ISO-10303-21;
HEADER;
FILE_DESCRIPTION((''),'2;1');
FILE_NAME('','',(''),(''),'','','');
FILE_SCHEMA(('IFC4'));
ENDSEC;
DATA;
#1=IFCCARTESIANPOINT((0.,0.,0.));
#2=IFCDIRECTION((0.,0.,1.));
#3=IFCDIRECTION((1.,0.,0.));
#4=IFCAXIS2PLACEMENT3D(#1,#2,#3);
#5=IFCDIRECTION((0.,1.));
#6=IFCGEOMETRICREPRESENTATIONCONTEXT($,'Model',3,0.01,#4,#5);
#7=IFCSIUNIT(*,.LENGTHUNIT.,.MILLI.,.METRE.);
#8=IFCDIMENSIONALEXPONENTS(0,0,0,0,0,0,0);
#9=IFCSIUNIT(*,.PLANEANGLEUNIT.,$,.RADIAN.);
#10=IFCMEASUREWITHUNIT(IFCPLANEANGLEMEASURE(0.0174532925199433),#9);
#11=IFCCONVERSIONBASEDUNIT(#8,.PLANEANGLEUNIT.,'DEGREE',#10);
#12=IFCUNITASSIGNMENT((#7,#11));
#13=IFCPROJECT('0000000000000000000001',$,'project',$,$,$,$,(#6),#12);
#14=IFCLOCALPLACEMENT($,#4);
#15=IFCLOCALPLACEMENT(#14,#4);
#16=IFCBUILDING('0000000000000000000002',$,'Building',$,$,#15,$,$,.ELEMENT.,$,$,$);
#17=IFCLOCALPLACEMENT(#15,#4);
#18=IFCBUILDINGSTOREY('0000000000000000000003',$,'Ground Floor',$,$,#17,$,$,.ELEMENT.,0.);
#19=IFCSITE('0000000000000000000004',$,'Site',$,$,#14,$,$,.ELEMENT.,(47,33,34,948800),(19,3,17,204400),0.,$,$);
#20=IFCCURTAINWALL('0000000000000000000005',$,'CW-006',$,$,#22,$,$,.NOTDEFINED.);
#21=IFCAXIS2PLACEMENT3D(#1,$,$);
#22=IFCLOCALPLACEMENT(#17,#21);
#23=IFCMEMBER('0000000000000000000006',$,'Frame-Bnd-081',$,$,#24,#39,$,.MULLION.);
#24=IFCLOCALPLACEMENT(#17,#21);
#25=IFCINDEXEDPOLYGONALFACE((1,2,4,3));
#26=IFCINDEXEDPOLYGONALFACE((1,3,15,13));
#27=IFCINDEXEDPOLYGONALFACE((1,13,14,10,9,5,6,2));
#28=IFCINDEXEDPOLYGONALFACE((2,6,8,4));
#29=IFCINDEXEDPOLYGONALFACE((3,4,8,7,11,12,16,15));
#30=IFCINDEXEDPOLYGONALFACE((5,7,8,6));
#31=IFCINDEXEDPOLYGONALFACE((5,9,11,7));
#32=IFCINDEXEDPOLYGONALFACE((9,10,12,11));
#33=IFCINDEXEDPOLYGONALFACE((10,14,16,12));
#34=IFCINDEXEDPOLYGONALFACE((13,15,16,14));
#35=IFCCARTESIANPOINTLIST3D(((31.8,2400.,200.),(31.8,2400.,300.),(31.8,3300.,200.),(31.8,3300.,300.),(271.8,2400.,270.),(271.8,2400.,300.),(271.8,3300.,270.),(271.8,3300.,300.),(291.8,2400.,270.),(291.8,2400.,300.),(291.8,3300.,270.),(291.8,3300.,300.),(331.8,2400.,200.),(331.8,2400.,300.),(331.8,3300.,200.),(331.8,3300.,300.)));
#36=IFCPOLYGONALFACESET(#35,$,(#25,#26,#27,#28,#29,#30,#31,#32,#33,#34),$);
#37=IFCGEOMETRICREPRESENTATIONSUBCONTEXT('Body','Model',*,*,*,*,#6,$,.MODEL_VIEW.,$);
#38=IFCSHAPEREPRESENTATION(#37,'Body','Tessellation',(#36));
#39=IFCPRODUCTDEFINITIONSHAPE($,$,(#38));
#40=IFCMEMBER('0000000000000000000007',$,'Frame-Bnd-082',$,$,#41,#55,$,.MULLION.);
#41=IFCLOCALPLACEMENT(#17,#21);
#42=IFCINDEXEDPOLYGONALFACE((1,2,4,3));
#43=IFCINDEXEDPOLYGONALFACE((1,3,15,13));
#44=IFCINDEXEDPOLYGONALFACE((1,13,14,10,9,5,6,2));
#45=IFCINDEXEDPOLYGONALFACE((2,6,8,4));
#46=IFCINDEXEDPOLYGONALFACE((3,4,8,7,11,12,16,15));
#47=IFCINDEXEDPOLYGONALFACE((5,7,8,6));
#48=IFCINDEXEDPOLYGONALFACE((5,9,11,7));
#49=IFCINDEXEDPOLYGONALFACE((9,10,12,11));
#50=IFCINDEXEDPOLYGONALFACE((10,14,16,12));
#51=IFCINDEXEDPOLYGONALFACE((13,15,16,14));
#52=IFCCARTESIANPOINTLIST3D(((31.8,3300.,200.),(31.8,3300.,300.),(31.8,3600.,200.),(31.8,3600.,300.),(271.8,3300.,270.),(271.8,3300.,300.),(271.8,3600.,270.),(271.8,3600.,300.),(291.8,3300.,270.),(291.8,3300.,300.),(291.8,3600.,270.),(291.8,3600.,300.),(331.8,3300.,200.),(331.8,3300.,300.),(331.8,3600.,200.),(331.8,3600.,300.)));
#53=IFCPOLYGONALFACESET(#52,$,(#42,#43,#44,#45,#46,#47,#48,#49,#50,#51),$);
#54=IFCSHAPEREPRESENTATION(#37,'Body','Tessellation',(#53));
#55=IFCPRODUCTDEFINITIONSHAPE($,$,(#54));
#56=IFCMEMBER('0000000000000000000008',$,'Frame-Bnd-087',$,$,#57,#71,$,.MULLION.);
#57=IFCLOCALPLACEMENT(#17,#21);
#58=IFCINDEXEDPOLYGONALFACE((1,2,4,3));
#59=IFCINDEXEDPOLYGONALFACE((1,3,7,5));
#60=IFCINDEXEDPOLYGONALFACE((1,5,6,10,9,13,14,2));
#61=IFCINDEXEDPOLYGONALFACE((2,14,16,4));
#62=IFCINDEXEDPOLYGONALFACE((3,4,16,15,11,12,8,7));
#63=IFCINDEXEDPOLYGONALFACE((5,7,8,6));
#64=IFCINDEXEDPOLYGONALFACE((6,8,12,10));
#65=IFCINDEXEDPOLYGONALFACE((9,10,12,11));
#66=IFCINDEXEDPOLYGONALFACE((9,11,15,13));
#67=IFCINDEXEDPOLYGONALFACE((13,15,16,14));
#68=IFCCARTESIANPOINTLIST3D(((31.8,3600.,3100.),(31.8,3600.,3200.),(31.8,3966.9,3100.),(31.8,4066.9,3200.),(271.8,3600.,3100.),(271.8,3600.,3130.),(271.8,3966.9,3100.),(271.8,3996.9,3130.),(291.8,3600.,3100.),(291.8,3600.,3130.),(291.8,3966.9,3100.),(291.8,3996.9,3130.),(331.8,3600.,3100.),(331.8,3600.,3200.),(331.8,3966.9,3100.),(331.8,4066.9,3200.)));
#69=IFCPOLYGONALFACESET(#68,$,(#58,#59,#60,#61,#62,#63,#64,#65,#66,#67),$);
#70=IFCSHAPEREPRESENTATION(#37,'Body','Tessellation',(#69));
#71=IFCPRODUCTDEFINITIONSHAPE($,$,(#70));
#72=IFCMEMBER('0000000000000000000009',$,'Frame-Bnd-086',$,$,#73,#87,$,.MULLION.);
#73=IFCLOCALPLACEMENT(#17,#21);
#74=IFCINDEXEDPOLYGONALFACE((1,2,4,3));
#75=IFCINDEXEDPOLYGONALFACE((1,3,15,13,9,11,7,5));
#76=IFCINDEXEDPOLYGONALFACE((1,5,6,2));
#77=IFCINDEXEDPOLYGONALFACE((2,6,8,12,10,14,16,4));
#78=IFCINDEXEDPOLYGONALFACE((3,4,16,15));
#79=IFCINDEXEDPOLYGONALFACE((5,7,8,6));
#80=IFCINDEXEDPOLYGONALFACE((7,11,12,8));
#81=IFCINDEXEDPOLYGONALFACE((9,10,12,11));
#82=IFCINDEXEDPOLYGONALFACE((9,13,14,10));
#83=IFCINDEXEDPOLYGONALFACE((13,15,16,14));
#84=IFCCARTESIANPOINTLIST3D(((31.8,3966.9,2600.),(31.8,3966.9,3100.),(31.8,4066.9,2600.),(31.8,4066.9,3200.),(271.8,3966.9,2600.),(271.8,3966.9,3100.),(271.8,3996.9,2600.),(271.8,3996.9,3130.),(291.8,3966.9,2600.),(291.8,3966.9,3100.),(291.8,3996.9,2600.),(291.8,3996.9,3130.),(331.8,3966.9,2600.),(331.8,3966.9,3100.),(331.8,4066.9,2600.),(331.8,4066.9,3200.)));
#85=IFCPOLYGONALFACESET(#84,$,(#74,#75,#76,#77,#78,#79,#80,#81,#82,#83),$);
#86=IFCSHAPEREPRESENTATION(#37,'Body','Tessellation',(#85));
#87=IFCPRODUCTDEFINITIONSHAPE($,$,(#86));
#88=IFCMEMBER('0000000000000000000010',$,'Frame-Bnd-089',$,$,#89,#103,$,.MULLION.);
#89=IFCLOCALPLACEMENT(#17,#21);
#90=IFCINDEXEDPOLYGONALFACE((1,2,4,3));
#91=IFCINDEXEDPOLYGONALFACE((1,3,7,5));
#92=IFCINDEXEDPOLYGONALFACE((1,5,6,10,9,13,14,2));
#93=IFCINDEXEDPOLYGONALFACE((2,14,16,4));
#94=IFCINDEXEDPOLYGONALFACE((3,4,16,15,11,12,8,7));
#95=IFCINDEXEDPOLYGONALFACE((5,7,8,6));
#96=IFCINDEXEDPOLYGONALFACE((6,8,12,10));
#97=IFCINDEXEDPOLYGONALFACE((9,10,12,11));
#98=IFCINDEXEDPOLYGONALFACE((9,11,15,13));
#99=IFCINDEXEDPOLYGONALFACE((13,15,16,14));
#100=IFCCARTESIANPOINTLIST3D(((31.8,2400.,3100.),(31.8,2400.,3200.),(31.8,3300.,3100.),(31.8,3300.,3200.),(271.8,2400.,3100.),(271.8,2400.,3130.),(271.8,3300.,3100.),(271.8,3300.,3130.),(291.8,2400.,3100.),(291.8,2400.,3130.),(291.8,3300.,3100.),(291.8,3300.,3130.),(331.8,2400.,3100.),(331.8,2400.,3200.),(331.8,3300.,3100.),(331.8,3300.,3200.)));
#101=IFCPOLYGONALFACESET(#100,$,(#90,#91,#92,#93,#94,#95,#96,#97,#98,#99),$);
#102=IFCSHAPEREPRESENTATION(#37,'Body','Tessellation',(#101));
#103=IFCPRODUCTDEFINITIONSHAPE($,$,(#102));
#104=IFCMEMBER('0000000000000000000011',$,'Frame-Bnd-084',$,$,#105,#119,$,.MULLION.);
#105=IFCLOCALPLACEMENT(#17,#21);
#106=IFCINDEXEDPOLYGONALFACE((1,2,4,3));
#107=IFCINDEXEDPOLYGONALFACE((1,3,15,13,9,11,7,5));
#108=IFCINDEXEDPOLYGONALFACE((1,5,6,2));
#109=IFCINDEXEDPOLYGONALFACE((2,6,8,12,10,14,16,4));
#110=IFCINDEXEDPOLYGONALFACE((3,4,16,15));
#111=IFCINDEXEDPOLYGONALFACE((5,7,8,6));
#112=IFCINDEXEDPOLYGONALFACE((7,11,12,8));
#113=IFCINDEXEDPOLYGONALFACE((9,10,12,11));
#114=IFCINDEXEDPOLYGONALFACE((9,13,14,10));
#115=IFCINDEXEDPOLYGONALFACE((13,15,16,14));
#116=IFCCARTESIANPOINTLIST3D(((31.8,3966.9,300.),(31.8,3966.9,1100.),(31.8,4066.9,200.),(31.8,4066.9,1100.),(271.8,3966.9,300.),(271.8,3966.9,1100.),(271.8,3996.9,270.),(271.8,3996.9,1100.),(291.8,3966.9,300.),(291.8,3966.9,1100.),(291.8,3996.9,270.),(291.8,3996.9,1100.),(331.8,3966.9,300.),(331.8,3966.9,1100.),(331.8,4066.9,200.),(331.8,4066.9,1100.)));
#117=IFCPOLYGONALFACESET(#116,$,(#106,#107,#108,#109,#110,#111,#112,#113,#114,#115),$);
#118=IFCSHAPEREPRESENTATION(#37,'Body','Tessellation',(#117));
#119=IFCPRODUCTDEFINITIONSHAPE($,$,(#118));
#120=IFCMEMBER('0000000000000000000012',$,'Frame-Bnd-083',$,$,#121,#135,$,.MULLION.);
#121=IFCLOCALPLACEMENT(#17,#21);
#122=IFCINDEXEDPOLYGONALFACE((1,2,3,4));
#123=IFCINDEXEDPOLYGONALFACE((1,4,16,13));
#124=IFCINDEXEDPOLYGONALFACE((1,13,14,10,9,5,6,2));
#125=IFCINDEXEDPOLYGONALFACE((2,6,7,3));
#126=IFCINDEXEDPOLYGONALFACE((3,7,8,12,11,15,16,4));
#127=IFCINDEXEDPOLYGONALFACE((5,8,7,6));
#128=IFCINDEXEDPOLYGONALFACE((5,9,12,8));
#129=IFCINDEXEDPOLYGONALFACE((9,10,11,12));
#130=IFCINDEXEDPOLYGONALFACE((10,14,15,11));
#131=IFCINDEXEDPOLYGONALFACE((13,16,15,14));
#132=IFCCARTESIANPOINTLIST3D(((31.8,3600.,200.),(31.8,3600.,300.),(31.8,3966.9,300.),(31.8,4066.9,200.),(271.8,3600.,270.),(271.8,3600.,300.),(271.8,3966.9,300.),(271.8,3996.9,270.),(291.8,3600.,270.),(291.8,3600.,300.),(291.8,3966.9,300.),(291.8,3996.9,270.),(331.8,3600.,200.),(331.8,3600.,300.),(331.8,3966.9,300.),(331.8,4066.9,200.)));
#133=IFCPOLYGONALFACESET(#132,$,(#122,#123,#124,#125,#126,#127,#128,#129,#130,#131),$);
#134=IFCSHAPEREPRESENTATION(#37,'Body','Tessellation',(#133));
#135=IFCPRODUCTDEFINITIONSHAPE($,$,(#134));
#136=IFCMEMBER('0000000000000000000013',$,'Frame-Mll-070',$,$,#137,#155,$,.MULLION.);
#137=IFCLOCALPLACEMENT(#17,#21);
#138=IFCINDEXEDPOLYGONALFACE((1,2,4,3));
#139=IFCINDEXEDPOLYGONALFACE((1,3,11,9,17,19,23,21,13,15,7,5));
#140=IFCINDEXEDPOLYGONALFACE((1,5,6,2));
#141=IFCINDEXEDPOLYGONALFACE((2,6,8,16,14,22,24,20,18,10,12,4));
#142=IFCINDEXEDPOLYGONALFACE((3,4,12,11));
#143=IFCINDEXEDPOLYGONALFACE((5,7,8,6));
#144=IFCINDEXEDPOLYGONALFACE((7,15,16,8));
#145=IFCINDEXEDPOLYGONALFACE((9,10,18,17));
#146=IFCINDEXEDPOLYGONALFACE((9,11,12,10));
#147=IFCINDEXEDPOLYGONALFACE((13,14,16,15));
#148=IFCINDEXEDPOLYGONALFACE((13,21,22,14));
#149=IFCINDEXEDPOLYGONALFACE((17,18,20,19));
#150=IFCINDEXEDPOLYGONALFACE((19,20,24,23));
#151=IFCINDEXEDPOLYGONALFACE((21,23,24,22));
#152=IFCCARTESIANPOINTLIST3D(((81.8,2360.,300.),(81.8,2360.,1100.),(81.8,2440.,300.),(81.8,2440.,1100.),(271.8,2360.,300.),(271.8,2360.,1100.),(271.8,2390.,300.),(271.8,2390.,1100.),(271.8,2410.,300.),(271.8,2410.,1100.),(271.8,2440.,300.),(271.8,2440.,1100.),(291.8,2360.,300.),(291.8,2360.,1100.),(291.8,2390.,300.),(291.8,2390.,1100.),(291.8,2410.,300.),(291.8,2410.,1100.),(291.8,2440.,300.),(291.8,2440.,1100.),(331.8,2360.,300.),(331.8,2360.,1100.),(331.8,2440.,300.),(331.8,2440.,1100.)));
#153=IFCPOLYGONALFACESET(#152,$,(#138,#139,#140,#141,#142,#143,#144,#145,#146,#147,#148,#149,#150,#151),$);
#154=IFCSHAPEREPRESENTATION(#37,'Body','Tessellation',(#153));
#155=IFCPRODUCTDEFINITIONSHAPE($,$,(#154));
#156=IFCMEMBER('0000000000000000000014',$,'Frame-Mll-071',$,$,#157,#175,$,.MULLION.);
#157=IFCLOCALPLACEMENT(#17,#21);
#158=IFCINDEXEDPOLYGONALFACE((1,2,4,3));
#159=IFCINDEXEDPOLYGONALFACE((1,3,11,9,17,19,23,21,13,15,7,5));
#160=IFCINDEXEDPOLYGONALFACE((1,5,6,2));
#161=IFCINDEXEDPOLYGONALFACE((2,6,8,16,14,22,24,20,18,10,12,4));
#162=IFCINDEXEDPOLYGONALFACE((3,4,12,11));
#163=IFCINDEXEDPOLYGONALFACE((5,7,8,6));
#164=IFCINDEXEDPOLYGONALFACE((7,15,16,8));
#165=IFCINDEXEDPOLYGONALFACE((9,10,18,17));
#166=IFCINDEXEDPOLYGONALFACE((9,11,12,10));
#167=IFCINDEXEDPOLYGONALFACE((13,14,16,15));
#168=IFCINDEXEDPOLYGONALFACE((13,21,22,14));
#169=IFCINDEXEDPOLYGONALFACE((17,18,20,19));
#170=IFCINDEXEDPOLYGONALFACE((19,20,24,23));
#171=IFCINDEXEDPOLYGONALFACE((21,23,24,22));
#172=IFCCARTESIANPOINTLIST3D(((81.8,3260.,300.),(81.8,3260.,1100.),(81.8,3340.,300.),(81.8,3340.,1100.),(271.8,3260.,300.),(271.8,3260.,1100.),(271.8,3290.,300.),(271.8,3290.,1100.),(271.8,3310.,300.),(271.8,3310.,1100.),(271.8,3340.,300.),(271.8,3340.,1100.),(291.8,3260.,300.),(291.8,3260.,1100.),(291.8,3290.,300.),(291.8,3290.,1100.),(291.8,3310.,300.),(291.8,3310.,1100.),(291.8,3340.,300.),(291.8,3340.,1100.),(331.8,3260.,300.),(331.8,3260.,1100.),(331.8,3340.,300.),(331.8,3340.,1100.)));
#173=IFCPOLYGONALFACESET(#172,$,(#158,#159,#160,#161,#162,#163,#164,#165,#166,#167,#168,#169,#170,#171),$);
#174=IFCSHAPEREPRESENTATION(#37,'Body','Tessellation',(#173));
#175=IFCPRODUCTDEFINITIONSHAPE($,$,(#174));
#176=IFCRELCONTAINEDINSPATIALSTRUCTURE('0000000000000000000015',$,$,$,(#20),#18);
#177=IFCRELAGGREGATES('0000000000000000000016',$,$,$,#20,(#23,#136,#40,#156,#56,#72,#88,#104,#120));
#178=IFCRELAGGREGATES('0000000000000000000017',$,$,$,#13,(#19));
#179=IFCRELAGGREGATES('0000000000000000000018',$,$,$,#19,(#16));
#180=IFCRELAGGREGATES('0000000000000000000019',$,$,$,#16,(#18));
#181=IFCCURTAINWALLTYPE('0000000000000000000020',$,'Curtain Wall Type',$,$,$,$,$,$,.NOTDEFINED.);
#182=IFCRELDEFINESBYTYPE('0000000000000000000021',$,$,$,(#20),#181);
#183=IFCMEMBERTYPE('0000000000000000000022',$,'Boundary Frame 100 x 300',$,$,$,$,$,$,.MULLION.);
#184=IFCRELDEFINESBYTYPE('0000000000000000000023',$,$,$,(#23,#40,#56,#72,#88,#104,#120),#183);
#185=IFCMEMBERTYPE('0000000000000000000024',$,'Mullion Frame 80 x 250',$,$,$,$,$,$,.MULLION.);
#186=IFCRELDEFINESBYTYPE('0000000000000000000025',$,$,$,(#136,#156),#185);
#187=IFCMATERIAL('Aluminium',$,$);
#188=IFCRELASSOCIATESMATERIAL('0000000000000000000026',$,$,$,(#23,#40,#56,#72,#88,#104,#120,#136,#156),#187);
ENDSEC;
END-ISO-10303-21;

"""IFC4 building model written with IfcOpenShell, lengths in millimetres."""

from ifc_helpers import new_model, entity, si_unit, converted_unit, direction, frame, origin_with_axes, place, context, subcontext, project, spatial, line, indexed_curve, outline, extrude, clip, halfspace, material, type_object, element, aggregate, save


model = new_model("IFC4")

# Units and contexts
model_context = context("Model", 3, precision=0.01, world=origin_with_axes(), true_north=direction((0.0, 1.0)))
body_context = subcontext(model_context, "Body", "Model", "MODEL_VIEW")
ifc_project = project(units=[si_unit("LENGTHUNIT", "METRE", prefix="MILLI"), converted_unit("PLANEANGLEUNIT", "DEGREE", entity("IfcPlaneAngleMeasure", 0.0174532925199433), si_unit("PLANEANGLEUNIT", "RADIAN"), dimensions=[0, 0, 0, 0, 0, 0, 0])], contexts=[model_context])

# Site, building, storey
site_placement = place(None, origin_with_axes())
site = spatial("IfcSite", under=ifc_project, at=site_placement, Name="Site", CompositionType="ELEMENT", RefLatitude=(47, 33, 34, 948800), RefLongitude=(19, 3, 17, 204400), RefElevation=0.0)
building_placement = place(site_placement, origin_with_axes())
building = spatial("IfcBuilding", under=site, at=building_placement, Name="Building", CompositionType="ELEMENT")
storey_placement = place(building_placement, origin_with_axes())
storey = spatial("IfcBuildingStorey", under=building, at=storey_placement, Name="Ground Floor", CompositionType="ELEMENT", Elevation=0.0)

# Curtain wall, members
curtain_wall_type = type_object("IfcCurtainWallType", Name="Curtain Wall Type", PredefinedType="NOTDEFINED")
curtain_wall_placement = place(storey_placement, frame((281.8, 450.0, 200.0), z_axis=(0.0, 0.0, 1.0), x_axis=(1.0, 0.0, 0.0)))
curtain_wall = element("IfcCurtainWall", 1, at=curtain_wall_placement, inside=storey, type_object=curtain_wall_type, Name="CW-006", PredefinedType="NOTDEFINED")
ifc_material_1 = material(Name="Aluminium")
member_type_1 = type_object("IfcMemberType", Name="Boundary Frame 100 x 300", PredefinedType="MULLION")
member_1_placement = place(curtain_wall_placement, frame((0.0, 1950.0, 0.0), z_axis=(0.0, 1.0, 0.0), x_axis=(0.0, 0.0, 1.0)))
member_1 = element("IfcMember", 2, at=member_1_placement, type_object=member_type_1, material=ifc_material_1, Name="Frame-Bnd-081", PredefinedType="MULLION", context=body_context, shape_type="SweptSolid", body=[
    extrude(outline(indexed_curve([(70.0, -10.0), (70.0, 10.0), (100.0, 10.0), (100.0, 50.0), (0.0, 50.0), (0.0, -250.0), (100.0, -250.0), (100.0, -10.0)], segments=[line(1, 2, 3, 4, 5, 6, 7, 8, 1)])), origin_with_axes(), (0.0, 0.0, 1.0), 900.0),
])
member_2_placement = place(curtain_wall_placement, frame((0.0, 2850.0, 0.0), z_axis=(0.0, 1.0, 0.0), x_axis=(0.0, 0.0, 1.0)))
member_2 = element("IfcMember", 3, at=member_2_placement, type_object=member_type_1, material=ifc_material_1, Name="Frame-Bnd-082", PredefinedType="MULLION", context=body_context, shape_type="SweptSolid", body=[
    extrude(outline(indexed_curve([(70.0, -10.0), (70.0, 10.0), (100.0, 10.0), (100.0, 50.0), (0.0, 50.0), (0.0, -250.0), (100.0, -250.0), (100.0, -10.0)], segments=[line(1, 2, 3, 4, 5, 6, 7, 8, 1)])), origin_with_axes(), (0.0, 0.0, 1.0), 300.0),
])
member_3_placement = place(curtain_wall_placement, frame((0.0, 3150.0, 3000.0), z_axis=(0.0, 1.0, 0.0), x_axis=(0.0, 0.0, 1.0)))
member_3 = element("IfcMember", 4, at=member_3_placement, type_object=member_type_1, material=ifc_material_1, Name="Frame-Bnd-087", PredefinedType="MULLION", context=body_context, shape_type="Clipping", body=[
    clip(extrude(outline(indexed_curve([(-70.0, -10.0), (-100.0, -10.0), (-100.0, -250.0), (0.0, -250.0), (0.0, 50.0), (-100.0, 50.0), (-100.0, 10.0), (-70.0, 10.0)], segments=[line(1, 2, 3, 4, 5, 6, 7, 8, 1)])), origin_with_axes(), (0.0, 0.0, 1.0), 466.9), halfspace(frame((-233.4, 0.0, 233.4), z_axis=(0.707107, 0.0, -0.707107), x_axis=(0.0, 1.0, 0.0)), True)),
])
member_4_placement = place(curtain_wall_placement, frame((0.0, 3616.9, 2400.0), z_axis=(0.0, 0.0, 1.0), x_axis=(0.0, -1.0, 0.0)))
member_4 = element("IfcMember", 5, at=member_4_placement, type_object=member_type_1, material=ifc_material_1, Name="Frame-Bnd-086", PredefinedType="MULLION", context=body_context, shape_type="Clipping", body=[
    clip(extrude(outline(indexed_curve([(70.0, -10.0), (70.0, 10.0), (100.0, 10.0), (100.0, 50.0), (0.0, 50.0), (0.0, -250.0), (100.0, -250.0), (100.0, -10.0)], segments=[line(1, 2, 3, 4, 5, 6, 7, 8, 1)])), origin_with_axes(), (0.0, 0.0, 1.0), 600.0), halfspace(frame((300.0, 0.0, 300.0), z_axis=(-0.707107, 0.0, -0.707107), x_axis=(0.0, 1.0, 0.0)), True)),
])
member_5_placement = place(curtain_wall_placement, frame((0.0, 1950.0, 3000.0), z_axis=(0.0, 1.0, 0.0), x_axis=(0.0, 0.0, 1.0)))
member_5 = element("IfcMember", 6, at=member_5_placement, type_object=member_type_1, material=ifc_material_1, Name="Frame-Bnd-089", PredefinedType="MULLION", context=body_context, shape_type="SweptSolid", body=[
    extrude(outline(indexed_curve([(-70.0, -10.0), (-100.0, -10.0), (-100.0, -250.0), (0.0, -250.0), (0.0, 50.0), (-100.0, 50.0), (-100.0, 10.0), (-70.0, 10.0)], segments=[line(1, 2, 3, 4, 5, 6, 7, 8, 1)])), origin_with_axes(), (0.0, 0.0, 1.0), 900.0),
])
member_6_placement = place(curtain_wall_placement, frame((0.0, 3616.9, 0.0), z_axis=(0.0, 0.0, 1.0), x_axis=(0.0, -1.0, 0.0)))
member_6 = element("IfcMember", 7, at=member_6_placement, type_object=member_type_1, material=ifc_material_1, Name="Frame-Bnd-084", PredefinedType="MULLION", context=body_context, shape_type="Clipping", body=[
    clip(extrude(outline(indexed_curve([(70.0, -10.0), (70.0, 10.0), (100.0, 10.0), (100.0, 50.0), (0.0, 50.0), (0.0, -250.0), (100.0, -250.0), (100.0, -10.0)], segments=[line(1, 2, 3, 4, 5, 6, 7, 8, 1)])), origin_with_axes(), (0.0, 0.0, 1.0), 900.0), halfspace(frame((0.0, 0.0, 0.0), z_axis=(-0.707107, 0.0, 0.707107), x_axis=(0.0, -1.0, 0.0)), True)),
])
member_7_placement = place(curtain_wall_placement, frame((0.0, 3150.0, 0.0), z_axis=(0.0, 1.0, 0.0), x_axis=(0.0, 0.0, 1.0)))
member_7 = element("IfcMember", 8, at=member_7_placement, type_object=member_type_1, material=ifc_material_1, Name="Frame-Bnd-083", PredefinedType="MULLION", context=body_context, shape_type="Clipping", body=[
    clip(extrude(outline(indexed_curve([(70.0, -10.0), (70.0, 10.0), (100.0, 10.0), (100.0, 50.0), (0.0, 50.0), (0.0, -250.0), (100.0, -250.0), (100.0, -10.0)], segments=[line(1, 2, 3, 4, 5, 6, 7, 8, 1)])), origin_with_axes(), (0.0, 0.0, 1.0), 466.9), halfspace(frame((233.4, 0.0, 233.4), z_axis=(-0.707107, 0.0, -0.707107), x_axis=(0.0, 1.0, 0.0)), True)),
])
member_type_2 = type_object("IfcMemberType", Name="Mullion Frame 80 x 250", PredefinedType="MULLION")
member_8_placement = place(curtain_wall_placement, frame((0.0, 1950.0, 0.0), z_axis=(0.0, 0.0, 1.0), x_axis=(0.0, -1.0, 0.0)))
member_8 = element("IfcMember", 9, at=member_8_placement, type_object=member_type_2, material=ifc_material_1, Name="Frame-Mll-070", PredefinedType="MULLION", context=body_context, shape_type="SweptSolid", body=[
    extrude(outline(indexed_curve([(-10.0, -10.0), (-40.0, -10.0), (-40.0, -200.0), (40.0, -200.0), (40.0, -10.0), (10.0, -10.0), (10.0, 10.0), (40.0, 10.0), (40.0, 50.0), (-40.0, 50.0), (-40.0, 10.0), (-10.0, 10.0)], segments=[line(1, 2, 3, 4, 5, 6, 7, 8, 9, 10, 11, 12, 1)])), frame((0.0, 0.0, 100.0), z_axis=(0.0, 0.0, 1.0), x_axis=(1.0, 0.0, 0.0)), (0.0, 0.0, 1.0), 800.0),
])
member_9_placement = place(curtain_wall_placement, frame((0.0, 2850.0, 0.0), z_axis=(0.0, 0.0, 1.0), x_axis=(0.0, -1.0, 0.0)))
member_9 = element("IfcMember", 10, at=member_9_placement, type_object=member_type_2, material=ifc_material_1, Name="Frame-Mll-071", PredefinedType="MULLION", context=body_context, shape_type="SweptSolid", body=[
    extrude(outline(indexed_curve([(-10.0, -10.0), (-40.0, -10.0), (-40.0, -200.0), (40.0, -200.0), (40.0, -10.0), (10.0, -10.0), (10.0, 10.0), (40.0, 10.0), (40.0, 50.0), (-40.0, 50.0), (-40.0, 10.0), (-10.0, 10.0)], segments=[line(1, 2, 3, 4, 5, 6, 7, 8, 9, 10, 11, 12, 1)])), frame((0.0, 0.0, 100.0), z_axis=(0.0, 0.0, 1.0), x_axis=(1.0, 0.0, 0.0)), (0.0, 0.0, 1.0), 800.0),
])
aggregate(curtain_wall, [member_1, member_8, member_2, member_9, member_3, member_4, member_5, member_6, member_7])

save(model, "model.ifc")
